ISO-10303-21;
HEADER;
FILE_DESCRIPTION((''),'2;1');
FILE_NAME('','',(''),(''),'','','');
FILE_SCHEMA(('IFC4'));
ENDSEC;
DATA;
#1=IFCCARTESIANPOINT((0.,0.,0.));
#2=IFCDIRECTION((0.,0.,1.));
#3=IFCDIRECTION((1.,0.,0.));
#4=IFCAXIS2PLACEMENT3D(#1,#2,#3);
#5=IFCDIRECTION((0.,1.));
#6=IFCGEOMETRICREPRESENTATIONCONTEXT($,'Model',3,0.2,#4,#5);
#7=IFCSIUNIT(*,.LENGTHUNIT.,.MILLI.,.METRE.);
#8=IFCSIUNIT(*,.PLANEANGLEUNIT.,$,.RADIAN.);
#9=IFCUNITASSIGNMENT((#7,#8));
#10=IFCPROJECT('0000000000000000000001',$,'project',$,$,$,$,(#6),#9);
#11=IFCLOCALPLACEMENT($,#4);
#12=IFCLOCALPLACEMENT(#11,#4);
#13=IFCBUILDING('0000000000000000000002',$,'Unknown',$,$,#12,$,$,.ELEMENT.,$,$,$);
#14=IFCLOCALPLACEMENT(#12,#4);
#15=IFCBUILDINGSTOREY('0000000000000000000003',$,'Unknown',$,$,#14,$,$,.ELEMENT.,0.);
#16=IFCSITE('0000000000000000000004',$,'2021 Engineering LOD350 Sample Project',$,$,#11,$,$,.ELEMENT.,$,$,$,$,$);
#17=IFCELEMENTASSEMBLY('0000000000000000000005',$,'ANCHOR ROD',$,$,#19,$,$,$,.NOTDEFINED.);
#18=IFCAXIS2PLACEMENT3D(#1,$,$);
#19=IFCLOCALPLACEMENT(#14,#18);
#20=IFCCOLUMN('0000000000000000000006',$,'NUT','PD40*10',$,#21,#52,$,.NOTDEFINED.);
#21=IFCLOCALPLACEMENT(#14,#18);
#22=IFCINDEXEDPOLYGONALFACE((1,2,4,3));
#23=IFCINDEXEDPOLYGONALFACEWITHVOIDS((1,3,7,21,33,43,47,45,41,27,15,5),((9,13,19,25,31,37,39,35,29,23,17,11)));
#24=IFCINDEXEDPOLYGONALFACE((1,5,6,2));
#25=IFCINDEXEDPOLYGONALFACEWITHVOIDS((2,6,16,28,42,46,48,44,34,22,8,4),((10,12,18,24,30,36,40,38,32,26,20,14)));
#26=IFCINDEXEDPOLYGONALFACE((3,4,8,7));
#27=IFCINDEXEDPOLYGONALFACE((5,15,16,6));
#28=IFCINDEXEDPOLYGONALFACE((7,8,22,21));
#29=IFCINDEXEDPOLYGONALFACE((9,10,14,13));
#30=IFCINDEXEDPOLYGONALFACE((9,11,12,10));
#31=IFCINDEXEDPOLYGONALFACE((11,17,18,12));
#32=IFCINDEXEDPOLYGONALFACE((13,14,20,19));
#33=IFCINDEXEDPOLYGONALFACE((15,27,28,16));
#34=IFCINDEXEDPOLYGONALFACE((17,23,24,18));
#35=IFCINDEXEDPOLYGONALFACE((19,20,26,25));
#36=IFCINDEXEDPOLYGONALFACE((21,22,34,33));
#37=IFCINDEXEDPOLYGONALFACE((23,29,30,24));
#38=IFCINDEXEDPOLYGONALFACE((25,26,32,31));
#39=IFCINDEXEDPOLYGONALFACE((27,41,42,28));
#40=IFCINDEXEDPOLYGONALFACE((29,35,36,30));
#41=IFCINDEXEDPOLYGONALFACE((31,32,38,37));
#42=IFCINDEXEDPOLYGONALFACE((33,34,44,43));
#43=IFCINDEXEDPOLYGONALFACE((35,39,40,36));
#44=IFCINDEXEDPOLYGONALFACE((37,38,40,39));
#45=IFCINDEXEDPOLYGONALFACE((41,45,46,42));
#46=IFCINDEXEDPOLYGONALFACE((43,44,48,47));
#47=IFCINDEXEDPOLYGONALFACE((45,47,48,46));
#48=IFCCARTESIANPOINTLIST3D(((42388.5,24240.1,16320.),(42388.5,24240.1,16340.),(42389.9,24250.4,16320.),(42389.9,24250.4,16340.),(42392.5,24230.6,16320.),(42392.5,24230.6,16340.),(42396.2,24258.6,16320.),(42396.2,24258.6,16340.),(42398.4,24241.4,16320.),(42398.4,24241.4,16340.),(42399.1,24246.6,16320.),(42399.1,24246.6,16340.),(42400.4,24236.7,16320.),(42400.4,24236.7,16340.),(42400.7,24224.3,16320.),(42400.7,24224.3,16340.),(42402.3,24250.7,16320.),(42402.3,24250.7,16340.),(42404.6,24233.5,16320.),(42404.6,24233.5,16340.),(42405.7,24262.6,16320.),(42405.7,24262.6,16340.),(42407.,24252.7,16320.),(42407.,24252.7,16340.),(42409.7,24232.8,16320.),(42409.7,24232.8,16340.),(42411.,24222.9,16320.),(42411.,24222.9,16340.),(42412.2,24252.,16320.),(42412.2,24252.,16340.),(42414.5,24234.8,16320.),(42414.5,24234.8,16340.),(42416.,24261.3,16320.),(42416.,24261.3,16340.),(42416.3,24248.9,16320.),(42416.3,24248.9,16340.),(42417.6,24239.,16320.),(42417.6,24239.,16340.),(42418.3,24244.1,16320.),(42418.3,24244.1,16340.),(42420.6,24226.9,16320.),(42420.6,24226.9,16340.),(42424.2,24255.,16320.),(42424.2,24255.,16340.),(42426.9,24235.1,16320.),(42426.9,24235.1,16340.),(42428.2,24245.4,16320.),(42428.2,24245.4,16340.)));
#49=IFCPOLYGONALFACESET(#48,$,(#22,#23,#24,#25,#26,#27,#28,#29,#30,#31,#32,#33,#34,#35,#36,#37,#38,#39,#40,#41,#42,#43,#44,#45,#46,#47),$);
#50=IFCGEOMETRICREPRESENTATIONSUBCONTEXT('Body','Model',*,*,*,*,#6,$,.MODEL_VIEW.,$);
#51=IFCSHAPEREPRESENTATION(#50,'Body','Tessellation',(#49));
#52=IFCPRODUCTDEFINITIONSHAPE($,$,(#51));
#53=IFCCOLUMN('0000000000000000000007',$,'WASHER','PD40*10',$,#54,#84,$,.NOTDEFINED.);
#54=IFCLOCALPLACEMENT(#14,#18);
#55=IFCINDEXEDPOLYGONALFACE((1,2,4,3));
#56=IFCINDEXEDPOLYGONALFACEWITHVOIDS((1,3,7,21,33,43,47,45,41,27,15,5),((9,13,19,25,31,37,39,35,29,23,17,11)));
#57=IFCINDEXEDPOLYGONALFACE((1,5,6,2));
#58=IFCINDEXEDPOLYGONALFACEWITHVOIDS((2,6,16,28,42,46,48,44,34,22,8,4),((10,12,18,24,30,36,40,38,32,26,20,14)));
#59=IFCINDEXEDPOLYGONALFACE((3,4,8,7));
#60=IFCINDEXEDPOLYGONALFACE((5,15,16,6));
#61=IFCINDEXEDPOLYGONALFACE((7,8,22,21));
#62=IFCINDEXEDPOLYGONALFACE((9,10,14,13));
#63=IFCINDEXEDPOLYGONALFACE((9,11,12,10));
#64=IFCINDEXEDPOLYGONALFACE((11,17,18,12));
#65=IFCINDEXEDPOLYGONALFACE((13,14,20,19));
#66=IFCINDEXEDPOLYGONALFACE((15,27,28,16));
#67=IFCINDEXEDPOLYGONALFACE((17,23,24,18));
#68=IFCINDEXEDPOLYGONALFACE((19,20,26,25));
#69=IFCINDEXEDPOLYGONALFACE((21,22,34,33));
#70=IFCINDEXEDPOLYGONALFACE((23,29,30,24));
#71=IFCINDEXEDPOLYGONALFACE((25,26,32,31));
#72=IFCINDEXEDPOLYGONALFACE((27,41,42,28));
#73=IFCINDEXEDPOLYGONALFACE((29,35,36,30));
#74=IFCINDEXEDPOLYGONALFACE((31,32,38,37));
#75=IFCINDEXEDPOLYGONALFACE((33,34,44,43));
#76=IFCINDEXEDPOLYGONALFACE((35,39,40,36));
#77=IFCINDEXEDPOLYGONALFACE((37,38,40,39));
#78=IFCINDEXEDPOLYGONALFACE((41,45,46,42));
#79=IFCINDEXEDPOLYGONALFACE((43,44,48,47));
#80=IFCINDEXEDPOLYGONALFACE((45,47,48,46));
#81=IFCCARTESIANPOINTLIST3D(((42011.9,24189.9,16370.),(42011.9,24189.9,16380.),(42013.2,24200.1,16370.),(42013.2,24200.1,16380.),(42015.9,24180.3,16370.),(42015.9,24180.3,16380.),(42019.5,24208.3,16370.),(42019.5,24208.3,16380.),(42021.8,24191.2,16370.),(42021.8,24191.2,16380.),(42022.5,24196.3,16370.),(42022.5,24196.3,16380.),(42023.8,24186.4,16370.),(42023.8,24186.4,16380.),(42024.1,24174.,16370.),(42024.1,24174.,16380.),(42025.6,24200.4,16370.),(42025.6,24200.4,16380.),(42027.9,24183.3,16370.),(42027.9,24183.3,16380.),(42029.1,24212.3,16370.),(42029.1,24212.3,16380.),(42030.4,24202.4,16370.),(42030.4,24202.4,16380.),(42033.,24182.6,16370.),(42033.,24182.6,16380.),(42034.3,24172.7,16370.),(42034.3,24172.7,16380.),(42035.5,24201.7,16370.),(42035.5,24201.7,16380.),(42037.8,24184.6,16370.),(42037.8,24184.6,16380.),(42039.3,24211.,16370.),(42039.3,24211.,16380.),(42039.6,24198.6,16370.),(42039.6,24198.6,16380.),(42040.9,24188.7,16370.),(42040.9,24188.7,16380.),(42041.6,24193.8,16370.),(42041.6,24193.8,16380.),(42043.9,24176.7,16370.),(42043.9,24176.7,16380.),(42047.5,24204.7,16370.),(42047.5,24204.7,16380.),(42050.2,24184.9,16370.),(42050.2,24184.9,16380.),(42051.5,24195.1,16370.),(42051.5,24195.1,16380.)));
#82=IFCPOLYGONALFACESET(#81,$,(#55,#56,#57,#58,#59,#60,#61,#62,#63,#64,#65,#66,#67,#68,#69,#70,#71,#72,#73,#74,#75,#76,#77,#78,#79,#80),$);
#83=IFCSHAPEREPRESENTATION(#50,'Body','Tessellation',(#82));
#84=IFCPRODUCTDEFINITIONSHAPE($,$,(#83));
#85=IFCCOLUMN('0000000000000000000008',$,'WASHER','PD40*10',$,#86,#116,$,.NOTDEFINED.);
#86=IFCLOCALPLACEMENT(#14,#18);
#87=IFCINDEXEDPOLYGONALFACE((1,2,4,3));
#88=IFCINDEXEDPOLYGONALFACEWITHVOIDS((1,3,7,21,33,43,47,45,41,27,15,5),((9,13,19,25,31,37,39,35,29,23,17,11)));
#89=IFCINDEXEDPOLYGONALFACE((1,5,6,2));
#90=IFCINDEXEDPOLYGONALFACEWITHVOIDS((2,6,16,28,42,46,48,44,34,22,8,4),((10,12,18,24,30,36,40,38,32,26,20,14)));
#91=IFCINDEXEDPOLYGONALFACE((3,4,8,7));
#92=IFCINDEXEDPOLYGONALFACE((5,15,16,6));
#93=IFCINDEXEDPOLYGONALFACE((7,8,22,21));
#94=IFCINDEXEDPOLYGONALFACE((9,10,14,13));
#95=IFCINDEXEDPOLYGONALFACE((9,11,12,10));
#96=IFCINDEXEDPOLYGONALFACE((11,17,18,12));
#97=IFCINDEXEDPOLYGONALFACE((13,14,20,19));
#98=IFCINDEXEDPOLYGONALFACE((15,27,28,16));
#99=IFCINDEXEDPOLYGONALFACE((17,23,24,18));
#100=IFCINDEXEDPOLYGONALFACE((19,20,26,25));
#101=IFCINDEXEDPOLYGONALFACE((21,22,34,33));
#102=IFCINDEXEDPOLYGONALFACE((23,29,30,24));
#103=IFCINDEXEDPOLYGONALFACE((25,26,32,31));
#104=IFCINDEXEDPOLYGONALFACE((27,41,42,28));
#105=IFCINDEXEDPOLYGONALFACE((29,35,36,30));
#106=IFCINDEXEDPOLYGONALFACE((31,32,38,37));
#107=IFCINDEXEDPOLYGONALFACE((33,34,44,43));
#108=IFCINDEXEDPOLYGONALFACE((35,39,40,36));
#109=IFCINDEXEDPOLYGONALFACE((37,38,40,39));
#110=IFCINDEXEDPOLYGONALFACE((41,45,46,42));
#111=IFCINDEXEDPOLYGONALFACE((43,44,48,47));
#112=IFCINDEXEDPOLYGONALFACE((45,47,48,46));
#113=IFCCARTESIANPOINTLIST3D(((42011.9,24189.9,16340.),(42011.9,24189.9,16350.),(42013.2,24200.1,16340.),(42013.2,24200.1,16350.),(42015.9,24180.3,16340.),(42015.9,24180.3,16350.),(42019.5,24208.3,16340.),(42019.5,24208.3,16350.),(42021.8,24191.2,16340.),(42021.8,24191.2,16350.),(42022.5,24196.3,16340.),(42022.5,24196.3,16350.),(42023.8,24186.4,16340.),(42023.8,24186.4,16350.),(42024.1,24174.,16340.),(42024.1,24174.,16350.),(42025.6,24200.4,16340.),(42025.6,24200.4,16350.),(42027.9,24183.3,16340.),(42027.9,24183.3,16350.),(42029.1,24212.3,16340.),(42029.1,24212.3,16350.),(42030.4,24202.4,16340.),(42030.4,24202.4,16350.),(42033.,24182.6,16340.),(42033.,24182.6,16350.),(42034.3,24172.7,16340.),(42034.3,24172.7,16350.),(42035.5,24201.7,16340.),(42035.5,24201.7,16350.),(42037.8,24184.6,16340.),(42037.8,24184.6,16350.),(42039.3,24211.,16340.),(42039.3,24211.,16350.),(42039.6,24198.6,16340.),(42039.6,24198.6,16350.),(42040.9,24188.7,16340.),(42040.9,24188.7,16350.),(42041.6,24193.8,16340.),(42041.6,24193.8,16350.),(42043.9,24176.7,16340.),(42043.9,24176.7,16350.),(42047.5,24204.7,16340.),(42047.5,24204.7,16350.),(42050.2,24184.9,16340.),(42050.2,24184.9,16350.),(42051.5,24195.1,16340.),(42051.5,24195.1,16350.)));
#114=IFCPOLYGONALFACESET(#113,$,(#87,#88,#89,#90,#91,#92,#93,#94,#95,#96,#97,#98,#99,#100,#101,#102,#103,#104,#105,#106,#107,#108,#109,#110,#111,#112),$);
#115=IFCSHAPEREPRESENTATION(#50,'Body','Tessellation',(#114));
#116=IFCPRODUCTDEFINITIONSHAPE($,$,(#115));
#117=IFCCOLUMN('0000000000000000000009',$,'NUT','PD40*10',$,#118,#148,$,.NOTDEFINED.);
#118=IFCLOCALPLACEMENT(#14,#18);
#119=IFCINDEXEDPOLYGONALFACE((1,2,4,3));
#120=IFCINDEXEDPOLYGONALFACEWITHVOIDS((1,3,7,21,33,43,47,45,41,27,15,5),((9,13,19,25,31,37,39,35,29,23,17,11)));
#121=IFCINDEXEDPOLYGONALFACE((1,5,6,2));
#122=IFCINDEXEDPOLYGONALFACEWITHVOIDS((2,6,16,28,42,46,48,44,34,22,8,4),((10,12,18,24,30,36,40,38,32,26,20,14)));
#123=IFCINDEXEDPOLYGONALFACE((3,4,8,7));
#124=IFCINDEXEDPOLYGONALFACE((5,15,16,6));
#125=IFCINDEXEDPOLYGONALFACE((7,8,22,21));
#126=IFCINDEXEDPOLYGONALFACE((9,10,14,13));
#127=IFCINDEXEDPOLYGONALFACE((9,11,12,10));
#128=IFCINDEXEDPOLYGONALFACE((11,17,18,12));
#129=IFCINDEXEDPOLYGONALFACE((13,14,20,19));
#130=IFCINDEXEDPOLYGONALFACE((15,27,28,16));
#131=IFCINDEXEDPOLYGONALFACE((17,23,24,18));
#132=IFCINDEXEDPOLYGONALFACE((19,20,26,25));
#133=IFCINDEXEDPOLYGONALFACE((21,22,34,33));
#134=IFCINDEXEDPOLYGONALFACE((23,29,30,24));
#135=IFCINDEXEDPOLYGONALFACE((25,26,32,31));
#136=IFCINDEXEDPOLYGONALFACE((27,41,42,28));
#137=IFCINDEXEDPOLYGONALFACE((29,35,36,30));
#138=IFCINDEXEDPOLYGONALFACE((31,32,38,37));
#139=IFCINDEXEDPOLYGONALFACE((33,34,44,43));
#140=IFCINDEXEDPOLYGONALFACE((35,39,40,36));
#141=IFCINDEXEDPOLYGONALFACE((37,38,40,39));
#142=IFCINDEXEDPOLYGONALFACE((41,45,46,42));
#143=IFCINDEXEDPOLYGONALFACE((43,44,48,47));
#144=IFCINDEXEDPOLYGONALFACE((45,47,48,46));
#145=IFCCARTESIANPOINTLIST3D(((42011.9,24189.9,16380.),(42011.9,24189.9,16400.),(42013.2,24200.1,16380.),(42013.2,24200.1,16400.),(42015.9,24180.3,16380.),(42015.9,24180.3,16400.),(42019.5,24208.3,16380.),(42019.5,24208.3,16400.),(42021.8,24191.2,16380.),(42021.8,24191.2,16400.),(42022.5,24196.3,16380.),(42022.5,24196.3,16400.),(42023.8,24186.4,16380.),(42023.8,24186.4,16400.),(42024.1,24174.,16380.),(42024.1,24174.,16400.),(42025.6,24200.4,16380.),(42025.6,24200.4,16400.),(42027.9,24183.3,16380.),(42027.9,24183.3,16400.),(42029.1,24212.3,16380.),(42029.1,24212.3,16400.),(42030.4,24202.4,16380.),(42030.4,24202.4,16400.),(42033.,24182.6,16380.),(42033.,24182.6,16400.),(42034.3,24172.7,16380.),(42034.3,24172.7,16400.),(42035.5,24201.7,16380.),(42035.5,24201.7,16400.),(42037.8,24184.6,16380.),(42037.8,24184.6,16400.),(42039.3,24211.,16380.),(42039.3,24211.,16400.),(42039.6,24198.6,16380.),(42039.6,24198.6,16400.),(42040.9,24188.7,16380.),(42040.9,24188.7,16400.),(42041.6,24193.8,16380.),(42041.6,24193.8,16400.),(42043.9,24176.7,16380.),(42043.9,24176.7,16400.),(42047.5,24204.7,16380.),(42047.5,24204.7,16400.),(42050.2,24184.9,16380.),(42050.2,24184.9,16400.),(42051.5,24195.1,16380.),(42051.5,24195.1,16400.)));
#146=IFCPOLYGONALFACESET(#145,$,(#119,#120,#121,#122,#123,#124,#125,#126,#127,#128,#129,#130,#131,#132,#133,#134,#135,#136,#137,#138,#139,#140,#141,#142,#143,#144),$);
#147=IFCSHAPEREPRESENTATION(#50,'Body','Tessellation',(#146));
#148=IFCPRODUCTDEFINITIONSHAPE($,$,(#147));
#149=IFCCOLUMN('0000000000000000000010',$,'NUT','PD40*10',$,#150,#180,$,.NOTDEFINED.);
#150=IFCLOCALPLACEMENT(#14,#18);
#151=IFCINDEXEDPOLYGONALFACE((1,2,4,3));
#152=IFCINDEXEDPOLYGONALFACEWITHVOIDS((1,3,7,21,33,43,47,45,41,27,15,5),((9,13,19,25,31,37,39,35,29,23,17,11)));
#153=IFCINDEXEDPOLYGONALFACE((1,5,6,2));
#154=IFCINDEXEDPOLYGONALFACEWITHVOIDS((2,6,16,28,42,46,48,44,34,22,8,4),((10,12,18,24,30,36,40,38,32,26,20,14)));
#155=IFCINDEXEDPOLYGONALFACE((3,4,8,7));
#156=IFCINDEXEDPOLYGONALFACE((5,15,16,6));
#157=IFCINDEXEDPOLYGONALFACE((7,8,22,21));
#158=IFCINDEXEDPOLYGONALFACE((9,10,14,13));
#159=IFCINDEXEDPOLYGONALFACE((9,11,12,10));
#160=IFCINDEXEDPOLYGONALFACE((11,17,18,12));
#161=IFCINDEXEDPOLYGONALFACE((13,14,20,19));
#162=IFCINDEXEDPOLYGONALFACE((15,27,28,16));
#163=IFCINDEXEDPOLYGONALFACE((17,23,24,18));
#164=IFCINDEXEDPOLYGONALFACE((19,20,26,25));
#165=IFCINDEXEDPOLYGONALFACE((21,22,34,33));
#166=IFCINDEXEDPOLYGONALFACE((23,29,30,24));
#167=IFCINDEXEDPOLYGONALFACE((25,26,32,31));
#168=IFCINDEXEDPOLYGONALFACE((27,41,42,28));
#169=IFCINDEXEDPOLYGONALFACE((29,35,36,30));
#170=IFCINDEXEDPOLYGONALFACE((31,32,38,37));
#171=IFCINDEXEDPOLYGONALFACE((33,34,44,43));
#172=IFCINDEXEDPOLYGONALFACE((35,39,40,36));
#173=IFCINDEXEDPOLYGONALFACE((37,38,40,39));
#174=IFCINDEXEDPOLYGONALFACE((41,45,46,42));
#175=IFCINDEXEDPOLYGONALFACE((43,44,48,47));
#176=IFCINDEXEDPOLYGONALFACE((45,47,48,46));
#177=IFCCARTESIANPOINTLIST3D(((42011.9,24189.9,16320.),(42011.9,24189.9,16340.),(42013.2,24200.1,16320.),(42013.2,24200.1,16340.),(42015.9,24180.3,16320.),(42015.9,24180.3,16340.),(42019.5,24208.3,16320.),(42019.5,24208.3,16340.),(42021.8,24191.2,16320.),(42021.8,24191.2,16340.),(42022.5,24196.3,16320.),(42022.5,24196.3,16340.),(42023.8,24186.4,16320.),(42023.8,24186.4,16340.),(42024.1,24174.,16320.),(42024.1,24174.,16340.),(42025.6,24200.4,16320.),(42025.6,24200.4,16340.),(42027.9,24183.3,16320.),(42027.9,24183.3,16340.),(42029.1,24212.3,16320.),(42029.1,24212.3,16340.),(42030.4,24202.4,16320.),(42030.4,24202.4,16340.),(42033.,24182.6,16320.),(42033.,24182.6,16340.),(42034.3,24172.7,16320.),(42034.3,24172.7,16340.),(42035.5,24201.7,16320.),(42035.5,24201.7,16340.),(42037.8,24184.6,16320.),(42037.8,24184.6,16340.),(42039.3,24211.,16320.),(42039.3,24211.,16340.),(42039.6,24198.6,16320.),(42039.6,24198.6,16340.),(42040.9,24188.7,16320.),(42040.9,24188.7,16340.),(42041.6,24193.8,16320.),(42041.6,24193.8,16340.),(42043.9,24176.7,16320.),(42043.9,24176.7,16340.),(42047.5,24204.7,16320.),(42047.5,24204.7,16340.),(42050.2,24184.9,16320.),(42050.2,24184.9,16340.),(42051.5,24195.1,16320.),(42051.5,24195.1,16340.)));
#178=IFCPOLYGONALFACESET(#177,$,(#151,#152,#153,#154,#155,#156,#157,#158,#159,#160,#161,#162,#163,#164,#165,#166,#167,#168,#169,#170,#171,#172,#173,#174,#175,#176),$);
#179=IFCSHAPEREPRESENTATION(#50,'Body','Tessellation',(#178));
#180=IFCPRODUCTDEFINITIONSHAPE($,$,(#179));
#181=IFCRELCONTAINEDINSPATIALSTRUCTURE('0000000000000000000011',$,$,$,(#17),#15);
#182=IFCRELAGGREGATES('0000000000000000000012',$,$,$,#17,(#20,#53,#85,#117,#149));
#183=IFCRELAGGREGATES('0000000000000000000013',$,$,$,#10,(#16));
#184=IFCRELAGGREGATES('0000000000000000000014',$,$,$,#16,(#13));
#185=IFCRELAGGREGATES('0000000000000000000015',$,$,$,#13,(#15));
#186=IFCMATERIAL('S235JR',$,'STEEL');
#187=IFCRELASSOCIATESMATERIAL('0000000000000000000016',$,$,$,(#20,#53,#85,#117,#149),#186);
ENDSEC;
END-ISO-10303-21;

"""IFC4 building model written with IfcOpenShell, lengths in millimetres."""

from ifc_helpers import new_model, si_unit, direction, frame, origin_with_axes, place, context, subcontext, project, spatial, line, indexed_curve, outline, extrude, material, element, aggregate, save


model = new_model("IFC4")

# Units and contexts
model_context = context("Model", 3, precision=0.2, world=origin_with_axes(), true_north=direction((0.0, 1.0)))
body_context = subcontext(model_context, "Body", "Model", "MODEL_VIEW")
ifc_project = project(units=[si_unit("LENGTHUNIT", "METRE", prefix="MILLI"), si_unit("PLANEANGLEUNIT", "RADIAN")], contexts=[model_context])

# Site, building, storey
site_placement = place(None, origin_with_axes())
site = spatial("IfcSite", under=ifc_project, at=site_placement, Name="2021 Engineering LOD350 Sample Project", CompositionType="ELEMENT")
building_placement = place(site_placement, origin_with_axes())
building = spatial("IfcBuilding", under=site, at=building_placement, Name="Unknown", CompositionType="ELEMENT")
storey_placement = place(building_placement, origin_with_axes())
storey = spatial("IfcBuildingStorey", under=building, at=storey_placement, Name="Unknown", CompositionType="ELEMENT", Elevation=0.0)

# Element assembly, columns
assembly_1_placement = place(storey_placement, frame((42408.4, 24242.8, 16410.0), z_axis=(0.991216, 0.132256, 0.0), x_axis=(0.0, 0.0, -1.0)))
assembly_1 = element("IfcElementAssembly", 1, at=assembly_1_placement, inside=storey, Name="ANCHOR ROD", PredefinedType="NOTDEFINED")
ifc_material_1 = material(Name="S235JR", Category="STEEL")
column_1_placement = place(assembly_1_placement, frame((70.0, 0.0, 0.0), z_axis=(0.0, 0.0, 1.0), x_axis=(1.0, 0.0, 0.0)))
column_1 = element("IfcColumn", 2, at=column_1_placement, material=ifc_material_1, Name="NUT", Description="PD40*10", PredefinedType="NOTDEFINED", context=body_context, shape_type="SolidModel", body=[
    extrude(outline(indexed_curve([(20.0, 0.0), (17.3, 10.0), (10.0, 17.3), (0.0, 20.0), (-10.0, 17.3), (-17.3, 10.0), (-20.0, 0.0), (-17.3, -10.0), (-10.0, -17.3), (0.0, -20.0), (10.0, -17.3), (17.3, -10.0)], segments=[line(1, 2, 3, 4, 5, 6, 7, 8, 9, 10, 11, 12, 1)]), holes=[indexed_curve([(10.0, 0.0), (8.7, -5.0), (5.0, -8.7), (0.0, -10.0), (-5.0, -8.7), (-8.7, -5.0), (-10.0, 0.0), (-8.7, 5.0), (-5.0, 8.7), (0.0, 10.0), (5.0, 8.7), (8.7, 5.0)], segments=[line(1, 2, 3, 4, 5, 6, 7, 8, 9, 10, 11, 12, 1)])]), frame((0.0, 0.0, 0.0), z_axis=(-1.0, 0.0, 0.0), x_axis=(0.0, 0.0, 1.0)), (0.0, 0.0, -1.0), 20.0),
])
column_2_placement = place(assembly_1_placement, frame((30.0, 0.0, -380.0), z_axis=(0.0, 0.0, -1.0), x_axis=(1.0, 0.0, 0.0)))
column_2 = element("IfcColumn", 3, at=column_2_placement, material=ifc_material_1, Name="WASHER", Description="PD40*10", PredefinedType="NOTDEFINED", context=body_context, shape_type="SolidModel", body=[
    extrude(outline(indexed_curve([(20.0, 0.0), (17.3, 10.0), (10.0, 17.3), (0.0, 20.0), (-10.0, 17.3), (-17.3, 10.0), (-20.0, 0.0), (-17.3, -10.0), (-10.0, -17.3), (0.0, -20.0), (10.0, -17.3), (17.3, -10.0)], segments=[line(1, 2, 3, 4, 5, 6, 7, 8, 9, 10, 11, 12, 1)]), holes=[indexed_curve([(10.0, 0.0), (8.7, -5.0), (5.0, -8.7), (0.0, -10.0), (-5.0, -8.7), (-8.7, -5.0), (-10.0, 0.0), (-8.7, 5.0), (-5.0, 8.7), (0.0, 10.0), (5.0, 8.7), (8.7, 5.0)], segments=[line(1, 2, 3, 4, 5, 6, 7, 8, 9, 10, 11, 12, 1)])]), frame((0.0, 0.0, 0.0), z_axis=(-1.0, 0.0, 0.0), x_axis=(0.0, 0.0, 1.0)), (0.0, 0.0, -1.0), 10.0),
])
column_3_placement = place(assembly_1_placement, frame((60.0, 0.0, -380.0), z_axis=(0.0, 0.0, -1.0), x_axis=(1.0, 0.0, 0.0)))
column_3 = element("IfcColumn", 4, at=column_3_placement, material=ifc_material_1, Name="WASHER", Description="PD40*10", PredefinedType="NOTDEFINED", context=body_context, shape_type="SolidModel", body=[
    extrude(outline(indexed_curve([(20.0, 0.0), (17.3, 10.0), (10.0, 17.3), (0.0, 20.0), (-10.0, 17.3), (-17.3, 10.0), (-20.0, 0.0), (-17.3, -10.0), (-10.0, -17.3), (0.0, -20.0), (10.0, -17.3), (17.3, -10.0)], segments=[line(1, 2, 3, 4, 5, 6, 7, 8, 9, 10, 11, 12, 1)]), holes=[indexed_curve([(10.0, 0.0), (8.7, -5.0), (5.0, -8.7), (0.0, -10.0), (-5.0, -8.7), (-8.7, -5.0), (-10.0, 0.0), (-8.7, 5.0), (-5.0, 8.7), (0.0, 10.0), (5.0, 8.7), (8.7, 5.0)], segments=[line(1, 2, 3, 4, 5, 6, 7, 8, 9, 10, 11, 12, 1)])]), frame((0.0, 0.0, 0.0), z_axis=(-1.0, 0.0, 0.0), x_axis=(0.0, 0.0, 1.0)), (0.0, 0.0, -1.0), 10.0),
])
column_4_placement = place(assembly_1_placement, frame((10.0, 0.0, -380.0), z_axis=(0.0, 0.0, -1.0), x_axis=(1.0, 0.0, 0.0)))
column_4 = element("IfcColumn", 5, at=column_4_placement, material=ifc_material_1, Name="NUT", Description="PD40*10", PredefinedType="NOTDEFINED", context=body_context, shape_type="SolidModel", body=[
    extrude(outline(indexed_curve([(20.0, 0.0), (17.3, 10.0), (10.0, 17.3), (0.0, 20.0), (-10.0, 17.3), (-17.3, 10.0), (-20.0, 0.0), (-17.3, -10.0), (-10.0, -17.3), (0.0, -20.0), (10.0, -17.3), (17.3, -10.0)], segments=[line(1, 2, 3, 4, 5, 6, 7, 8, 9, 10, 11, 12, 1)]), holes=[indexed_curve([(10.0, 0.0), (8.7, -5.0), (5.0, -8.7), (0.0, -10.0), (-5.0, -8.7), (-8.7, -5.0), (-10.0, 0.0), (-8.7, 5.0), (-5.0, 8.7), (0.0, 10.0), (5.0, 8.7), (8.7, 5.0)], segments=[line(1, 2, 3, 4, 5, 6, 7, 8, 9, 10, 11, 12, 1)])]), frame((0.0, 0.0, 0.0), z_axis=(-1.0, 0.0, 0.0), x_axis=(0.0, 0.0, 1.0)), (0.0, 0.0, -1.0), 20.0),
])
column_5_placement = place(assembly_1_placement, frame((70.0, 0.0, -380.0), z_axis=(0.0, 0.0, -1.0), x_axis=(1.0, 0.0, 0.0)))
column_5 = element("IfcColumn", 6, at=column_5_placement, material=ifc_material_1, Name="NUT", Description="PD40*10", PredefinedType="NOTDEFINED", context=body_context, shape_type="SolidModel", body=[
    extrude(outline(indexed_curve([(20.0, 0.0), (17.3, 10.0), (10.0, 17.3), (0.0, 20.0), (-10.0, 17.3), (-17.3, 10.0), (-20.0, 0.0), (-17.3, -10.0), (-10.0, -17.3), (0.0, -20.0), (10.0, -17.3), (17.3, -10.0)], segments=[line(1, 2, 3, 4, 5, 6, 7, 8, 9, 10, 11, 12, 1)]), holes=[indexed_curve([(10.0, 0.0), (8.7, -5.0), (5.0, -8.7), (0.0, -10.0), (-5.0, -8.7), (-8.7, -5.0), (-10.0, 0.0), (-8.7, 5.0), (-5.0, 8.7), (0.0, 10.0), (5.0, 8.7), (8.7, 5.0)], segments=[line(1, 2, 3, 4, 5, 6, 7, 8, 9, 10, 11, 12, 1)])]), frame((0.0, 0.0, 0.0), z_axis=(-1.0, 0.0, 0.0), x_axis=(0.0, 0.0, 1.0)), (0.0, 0.0, -1.0), 20.0),
])

aggregate(assembly_1, [column_1, column_2, column_3, column_4, column_5])

save(model, "model.ifc")
